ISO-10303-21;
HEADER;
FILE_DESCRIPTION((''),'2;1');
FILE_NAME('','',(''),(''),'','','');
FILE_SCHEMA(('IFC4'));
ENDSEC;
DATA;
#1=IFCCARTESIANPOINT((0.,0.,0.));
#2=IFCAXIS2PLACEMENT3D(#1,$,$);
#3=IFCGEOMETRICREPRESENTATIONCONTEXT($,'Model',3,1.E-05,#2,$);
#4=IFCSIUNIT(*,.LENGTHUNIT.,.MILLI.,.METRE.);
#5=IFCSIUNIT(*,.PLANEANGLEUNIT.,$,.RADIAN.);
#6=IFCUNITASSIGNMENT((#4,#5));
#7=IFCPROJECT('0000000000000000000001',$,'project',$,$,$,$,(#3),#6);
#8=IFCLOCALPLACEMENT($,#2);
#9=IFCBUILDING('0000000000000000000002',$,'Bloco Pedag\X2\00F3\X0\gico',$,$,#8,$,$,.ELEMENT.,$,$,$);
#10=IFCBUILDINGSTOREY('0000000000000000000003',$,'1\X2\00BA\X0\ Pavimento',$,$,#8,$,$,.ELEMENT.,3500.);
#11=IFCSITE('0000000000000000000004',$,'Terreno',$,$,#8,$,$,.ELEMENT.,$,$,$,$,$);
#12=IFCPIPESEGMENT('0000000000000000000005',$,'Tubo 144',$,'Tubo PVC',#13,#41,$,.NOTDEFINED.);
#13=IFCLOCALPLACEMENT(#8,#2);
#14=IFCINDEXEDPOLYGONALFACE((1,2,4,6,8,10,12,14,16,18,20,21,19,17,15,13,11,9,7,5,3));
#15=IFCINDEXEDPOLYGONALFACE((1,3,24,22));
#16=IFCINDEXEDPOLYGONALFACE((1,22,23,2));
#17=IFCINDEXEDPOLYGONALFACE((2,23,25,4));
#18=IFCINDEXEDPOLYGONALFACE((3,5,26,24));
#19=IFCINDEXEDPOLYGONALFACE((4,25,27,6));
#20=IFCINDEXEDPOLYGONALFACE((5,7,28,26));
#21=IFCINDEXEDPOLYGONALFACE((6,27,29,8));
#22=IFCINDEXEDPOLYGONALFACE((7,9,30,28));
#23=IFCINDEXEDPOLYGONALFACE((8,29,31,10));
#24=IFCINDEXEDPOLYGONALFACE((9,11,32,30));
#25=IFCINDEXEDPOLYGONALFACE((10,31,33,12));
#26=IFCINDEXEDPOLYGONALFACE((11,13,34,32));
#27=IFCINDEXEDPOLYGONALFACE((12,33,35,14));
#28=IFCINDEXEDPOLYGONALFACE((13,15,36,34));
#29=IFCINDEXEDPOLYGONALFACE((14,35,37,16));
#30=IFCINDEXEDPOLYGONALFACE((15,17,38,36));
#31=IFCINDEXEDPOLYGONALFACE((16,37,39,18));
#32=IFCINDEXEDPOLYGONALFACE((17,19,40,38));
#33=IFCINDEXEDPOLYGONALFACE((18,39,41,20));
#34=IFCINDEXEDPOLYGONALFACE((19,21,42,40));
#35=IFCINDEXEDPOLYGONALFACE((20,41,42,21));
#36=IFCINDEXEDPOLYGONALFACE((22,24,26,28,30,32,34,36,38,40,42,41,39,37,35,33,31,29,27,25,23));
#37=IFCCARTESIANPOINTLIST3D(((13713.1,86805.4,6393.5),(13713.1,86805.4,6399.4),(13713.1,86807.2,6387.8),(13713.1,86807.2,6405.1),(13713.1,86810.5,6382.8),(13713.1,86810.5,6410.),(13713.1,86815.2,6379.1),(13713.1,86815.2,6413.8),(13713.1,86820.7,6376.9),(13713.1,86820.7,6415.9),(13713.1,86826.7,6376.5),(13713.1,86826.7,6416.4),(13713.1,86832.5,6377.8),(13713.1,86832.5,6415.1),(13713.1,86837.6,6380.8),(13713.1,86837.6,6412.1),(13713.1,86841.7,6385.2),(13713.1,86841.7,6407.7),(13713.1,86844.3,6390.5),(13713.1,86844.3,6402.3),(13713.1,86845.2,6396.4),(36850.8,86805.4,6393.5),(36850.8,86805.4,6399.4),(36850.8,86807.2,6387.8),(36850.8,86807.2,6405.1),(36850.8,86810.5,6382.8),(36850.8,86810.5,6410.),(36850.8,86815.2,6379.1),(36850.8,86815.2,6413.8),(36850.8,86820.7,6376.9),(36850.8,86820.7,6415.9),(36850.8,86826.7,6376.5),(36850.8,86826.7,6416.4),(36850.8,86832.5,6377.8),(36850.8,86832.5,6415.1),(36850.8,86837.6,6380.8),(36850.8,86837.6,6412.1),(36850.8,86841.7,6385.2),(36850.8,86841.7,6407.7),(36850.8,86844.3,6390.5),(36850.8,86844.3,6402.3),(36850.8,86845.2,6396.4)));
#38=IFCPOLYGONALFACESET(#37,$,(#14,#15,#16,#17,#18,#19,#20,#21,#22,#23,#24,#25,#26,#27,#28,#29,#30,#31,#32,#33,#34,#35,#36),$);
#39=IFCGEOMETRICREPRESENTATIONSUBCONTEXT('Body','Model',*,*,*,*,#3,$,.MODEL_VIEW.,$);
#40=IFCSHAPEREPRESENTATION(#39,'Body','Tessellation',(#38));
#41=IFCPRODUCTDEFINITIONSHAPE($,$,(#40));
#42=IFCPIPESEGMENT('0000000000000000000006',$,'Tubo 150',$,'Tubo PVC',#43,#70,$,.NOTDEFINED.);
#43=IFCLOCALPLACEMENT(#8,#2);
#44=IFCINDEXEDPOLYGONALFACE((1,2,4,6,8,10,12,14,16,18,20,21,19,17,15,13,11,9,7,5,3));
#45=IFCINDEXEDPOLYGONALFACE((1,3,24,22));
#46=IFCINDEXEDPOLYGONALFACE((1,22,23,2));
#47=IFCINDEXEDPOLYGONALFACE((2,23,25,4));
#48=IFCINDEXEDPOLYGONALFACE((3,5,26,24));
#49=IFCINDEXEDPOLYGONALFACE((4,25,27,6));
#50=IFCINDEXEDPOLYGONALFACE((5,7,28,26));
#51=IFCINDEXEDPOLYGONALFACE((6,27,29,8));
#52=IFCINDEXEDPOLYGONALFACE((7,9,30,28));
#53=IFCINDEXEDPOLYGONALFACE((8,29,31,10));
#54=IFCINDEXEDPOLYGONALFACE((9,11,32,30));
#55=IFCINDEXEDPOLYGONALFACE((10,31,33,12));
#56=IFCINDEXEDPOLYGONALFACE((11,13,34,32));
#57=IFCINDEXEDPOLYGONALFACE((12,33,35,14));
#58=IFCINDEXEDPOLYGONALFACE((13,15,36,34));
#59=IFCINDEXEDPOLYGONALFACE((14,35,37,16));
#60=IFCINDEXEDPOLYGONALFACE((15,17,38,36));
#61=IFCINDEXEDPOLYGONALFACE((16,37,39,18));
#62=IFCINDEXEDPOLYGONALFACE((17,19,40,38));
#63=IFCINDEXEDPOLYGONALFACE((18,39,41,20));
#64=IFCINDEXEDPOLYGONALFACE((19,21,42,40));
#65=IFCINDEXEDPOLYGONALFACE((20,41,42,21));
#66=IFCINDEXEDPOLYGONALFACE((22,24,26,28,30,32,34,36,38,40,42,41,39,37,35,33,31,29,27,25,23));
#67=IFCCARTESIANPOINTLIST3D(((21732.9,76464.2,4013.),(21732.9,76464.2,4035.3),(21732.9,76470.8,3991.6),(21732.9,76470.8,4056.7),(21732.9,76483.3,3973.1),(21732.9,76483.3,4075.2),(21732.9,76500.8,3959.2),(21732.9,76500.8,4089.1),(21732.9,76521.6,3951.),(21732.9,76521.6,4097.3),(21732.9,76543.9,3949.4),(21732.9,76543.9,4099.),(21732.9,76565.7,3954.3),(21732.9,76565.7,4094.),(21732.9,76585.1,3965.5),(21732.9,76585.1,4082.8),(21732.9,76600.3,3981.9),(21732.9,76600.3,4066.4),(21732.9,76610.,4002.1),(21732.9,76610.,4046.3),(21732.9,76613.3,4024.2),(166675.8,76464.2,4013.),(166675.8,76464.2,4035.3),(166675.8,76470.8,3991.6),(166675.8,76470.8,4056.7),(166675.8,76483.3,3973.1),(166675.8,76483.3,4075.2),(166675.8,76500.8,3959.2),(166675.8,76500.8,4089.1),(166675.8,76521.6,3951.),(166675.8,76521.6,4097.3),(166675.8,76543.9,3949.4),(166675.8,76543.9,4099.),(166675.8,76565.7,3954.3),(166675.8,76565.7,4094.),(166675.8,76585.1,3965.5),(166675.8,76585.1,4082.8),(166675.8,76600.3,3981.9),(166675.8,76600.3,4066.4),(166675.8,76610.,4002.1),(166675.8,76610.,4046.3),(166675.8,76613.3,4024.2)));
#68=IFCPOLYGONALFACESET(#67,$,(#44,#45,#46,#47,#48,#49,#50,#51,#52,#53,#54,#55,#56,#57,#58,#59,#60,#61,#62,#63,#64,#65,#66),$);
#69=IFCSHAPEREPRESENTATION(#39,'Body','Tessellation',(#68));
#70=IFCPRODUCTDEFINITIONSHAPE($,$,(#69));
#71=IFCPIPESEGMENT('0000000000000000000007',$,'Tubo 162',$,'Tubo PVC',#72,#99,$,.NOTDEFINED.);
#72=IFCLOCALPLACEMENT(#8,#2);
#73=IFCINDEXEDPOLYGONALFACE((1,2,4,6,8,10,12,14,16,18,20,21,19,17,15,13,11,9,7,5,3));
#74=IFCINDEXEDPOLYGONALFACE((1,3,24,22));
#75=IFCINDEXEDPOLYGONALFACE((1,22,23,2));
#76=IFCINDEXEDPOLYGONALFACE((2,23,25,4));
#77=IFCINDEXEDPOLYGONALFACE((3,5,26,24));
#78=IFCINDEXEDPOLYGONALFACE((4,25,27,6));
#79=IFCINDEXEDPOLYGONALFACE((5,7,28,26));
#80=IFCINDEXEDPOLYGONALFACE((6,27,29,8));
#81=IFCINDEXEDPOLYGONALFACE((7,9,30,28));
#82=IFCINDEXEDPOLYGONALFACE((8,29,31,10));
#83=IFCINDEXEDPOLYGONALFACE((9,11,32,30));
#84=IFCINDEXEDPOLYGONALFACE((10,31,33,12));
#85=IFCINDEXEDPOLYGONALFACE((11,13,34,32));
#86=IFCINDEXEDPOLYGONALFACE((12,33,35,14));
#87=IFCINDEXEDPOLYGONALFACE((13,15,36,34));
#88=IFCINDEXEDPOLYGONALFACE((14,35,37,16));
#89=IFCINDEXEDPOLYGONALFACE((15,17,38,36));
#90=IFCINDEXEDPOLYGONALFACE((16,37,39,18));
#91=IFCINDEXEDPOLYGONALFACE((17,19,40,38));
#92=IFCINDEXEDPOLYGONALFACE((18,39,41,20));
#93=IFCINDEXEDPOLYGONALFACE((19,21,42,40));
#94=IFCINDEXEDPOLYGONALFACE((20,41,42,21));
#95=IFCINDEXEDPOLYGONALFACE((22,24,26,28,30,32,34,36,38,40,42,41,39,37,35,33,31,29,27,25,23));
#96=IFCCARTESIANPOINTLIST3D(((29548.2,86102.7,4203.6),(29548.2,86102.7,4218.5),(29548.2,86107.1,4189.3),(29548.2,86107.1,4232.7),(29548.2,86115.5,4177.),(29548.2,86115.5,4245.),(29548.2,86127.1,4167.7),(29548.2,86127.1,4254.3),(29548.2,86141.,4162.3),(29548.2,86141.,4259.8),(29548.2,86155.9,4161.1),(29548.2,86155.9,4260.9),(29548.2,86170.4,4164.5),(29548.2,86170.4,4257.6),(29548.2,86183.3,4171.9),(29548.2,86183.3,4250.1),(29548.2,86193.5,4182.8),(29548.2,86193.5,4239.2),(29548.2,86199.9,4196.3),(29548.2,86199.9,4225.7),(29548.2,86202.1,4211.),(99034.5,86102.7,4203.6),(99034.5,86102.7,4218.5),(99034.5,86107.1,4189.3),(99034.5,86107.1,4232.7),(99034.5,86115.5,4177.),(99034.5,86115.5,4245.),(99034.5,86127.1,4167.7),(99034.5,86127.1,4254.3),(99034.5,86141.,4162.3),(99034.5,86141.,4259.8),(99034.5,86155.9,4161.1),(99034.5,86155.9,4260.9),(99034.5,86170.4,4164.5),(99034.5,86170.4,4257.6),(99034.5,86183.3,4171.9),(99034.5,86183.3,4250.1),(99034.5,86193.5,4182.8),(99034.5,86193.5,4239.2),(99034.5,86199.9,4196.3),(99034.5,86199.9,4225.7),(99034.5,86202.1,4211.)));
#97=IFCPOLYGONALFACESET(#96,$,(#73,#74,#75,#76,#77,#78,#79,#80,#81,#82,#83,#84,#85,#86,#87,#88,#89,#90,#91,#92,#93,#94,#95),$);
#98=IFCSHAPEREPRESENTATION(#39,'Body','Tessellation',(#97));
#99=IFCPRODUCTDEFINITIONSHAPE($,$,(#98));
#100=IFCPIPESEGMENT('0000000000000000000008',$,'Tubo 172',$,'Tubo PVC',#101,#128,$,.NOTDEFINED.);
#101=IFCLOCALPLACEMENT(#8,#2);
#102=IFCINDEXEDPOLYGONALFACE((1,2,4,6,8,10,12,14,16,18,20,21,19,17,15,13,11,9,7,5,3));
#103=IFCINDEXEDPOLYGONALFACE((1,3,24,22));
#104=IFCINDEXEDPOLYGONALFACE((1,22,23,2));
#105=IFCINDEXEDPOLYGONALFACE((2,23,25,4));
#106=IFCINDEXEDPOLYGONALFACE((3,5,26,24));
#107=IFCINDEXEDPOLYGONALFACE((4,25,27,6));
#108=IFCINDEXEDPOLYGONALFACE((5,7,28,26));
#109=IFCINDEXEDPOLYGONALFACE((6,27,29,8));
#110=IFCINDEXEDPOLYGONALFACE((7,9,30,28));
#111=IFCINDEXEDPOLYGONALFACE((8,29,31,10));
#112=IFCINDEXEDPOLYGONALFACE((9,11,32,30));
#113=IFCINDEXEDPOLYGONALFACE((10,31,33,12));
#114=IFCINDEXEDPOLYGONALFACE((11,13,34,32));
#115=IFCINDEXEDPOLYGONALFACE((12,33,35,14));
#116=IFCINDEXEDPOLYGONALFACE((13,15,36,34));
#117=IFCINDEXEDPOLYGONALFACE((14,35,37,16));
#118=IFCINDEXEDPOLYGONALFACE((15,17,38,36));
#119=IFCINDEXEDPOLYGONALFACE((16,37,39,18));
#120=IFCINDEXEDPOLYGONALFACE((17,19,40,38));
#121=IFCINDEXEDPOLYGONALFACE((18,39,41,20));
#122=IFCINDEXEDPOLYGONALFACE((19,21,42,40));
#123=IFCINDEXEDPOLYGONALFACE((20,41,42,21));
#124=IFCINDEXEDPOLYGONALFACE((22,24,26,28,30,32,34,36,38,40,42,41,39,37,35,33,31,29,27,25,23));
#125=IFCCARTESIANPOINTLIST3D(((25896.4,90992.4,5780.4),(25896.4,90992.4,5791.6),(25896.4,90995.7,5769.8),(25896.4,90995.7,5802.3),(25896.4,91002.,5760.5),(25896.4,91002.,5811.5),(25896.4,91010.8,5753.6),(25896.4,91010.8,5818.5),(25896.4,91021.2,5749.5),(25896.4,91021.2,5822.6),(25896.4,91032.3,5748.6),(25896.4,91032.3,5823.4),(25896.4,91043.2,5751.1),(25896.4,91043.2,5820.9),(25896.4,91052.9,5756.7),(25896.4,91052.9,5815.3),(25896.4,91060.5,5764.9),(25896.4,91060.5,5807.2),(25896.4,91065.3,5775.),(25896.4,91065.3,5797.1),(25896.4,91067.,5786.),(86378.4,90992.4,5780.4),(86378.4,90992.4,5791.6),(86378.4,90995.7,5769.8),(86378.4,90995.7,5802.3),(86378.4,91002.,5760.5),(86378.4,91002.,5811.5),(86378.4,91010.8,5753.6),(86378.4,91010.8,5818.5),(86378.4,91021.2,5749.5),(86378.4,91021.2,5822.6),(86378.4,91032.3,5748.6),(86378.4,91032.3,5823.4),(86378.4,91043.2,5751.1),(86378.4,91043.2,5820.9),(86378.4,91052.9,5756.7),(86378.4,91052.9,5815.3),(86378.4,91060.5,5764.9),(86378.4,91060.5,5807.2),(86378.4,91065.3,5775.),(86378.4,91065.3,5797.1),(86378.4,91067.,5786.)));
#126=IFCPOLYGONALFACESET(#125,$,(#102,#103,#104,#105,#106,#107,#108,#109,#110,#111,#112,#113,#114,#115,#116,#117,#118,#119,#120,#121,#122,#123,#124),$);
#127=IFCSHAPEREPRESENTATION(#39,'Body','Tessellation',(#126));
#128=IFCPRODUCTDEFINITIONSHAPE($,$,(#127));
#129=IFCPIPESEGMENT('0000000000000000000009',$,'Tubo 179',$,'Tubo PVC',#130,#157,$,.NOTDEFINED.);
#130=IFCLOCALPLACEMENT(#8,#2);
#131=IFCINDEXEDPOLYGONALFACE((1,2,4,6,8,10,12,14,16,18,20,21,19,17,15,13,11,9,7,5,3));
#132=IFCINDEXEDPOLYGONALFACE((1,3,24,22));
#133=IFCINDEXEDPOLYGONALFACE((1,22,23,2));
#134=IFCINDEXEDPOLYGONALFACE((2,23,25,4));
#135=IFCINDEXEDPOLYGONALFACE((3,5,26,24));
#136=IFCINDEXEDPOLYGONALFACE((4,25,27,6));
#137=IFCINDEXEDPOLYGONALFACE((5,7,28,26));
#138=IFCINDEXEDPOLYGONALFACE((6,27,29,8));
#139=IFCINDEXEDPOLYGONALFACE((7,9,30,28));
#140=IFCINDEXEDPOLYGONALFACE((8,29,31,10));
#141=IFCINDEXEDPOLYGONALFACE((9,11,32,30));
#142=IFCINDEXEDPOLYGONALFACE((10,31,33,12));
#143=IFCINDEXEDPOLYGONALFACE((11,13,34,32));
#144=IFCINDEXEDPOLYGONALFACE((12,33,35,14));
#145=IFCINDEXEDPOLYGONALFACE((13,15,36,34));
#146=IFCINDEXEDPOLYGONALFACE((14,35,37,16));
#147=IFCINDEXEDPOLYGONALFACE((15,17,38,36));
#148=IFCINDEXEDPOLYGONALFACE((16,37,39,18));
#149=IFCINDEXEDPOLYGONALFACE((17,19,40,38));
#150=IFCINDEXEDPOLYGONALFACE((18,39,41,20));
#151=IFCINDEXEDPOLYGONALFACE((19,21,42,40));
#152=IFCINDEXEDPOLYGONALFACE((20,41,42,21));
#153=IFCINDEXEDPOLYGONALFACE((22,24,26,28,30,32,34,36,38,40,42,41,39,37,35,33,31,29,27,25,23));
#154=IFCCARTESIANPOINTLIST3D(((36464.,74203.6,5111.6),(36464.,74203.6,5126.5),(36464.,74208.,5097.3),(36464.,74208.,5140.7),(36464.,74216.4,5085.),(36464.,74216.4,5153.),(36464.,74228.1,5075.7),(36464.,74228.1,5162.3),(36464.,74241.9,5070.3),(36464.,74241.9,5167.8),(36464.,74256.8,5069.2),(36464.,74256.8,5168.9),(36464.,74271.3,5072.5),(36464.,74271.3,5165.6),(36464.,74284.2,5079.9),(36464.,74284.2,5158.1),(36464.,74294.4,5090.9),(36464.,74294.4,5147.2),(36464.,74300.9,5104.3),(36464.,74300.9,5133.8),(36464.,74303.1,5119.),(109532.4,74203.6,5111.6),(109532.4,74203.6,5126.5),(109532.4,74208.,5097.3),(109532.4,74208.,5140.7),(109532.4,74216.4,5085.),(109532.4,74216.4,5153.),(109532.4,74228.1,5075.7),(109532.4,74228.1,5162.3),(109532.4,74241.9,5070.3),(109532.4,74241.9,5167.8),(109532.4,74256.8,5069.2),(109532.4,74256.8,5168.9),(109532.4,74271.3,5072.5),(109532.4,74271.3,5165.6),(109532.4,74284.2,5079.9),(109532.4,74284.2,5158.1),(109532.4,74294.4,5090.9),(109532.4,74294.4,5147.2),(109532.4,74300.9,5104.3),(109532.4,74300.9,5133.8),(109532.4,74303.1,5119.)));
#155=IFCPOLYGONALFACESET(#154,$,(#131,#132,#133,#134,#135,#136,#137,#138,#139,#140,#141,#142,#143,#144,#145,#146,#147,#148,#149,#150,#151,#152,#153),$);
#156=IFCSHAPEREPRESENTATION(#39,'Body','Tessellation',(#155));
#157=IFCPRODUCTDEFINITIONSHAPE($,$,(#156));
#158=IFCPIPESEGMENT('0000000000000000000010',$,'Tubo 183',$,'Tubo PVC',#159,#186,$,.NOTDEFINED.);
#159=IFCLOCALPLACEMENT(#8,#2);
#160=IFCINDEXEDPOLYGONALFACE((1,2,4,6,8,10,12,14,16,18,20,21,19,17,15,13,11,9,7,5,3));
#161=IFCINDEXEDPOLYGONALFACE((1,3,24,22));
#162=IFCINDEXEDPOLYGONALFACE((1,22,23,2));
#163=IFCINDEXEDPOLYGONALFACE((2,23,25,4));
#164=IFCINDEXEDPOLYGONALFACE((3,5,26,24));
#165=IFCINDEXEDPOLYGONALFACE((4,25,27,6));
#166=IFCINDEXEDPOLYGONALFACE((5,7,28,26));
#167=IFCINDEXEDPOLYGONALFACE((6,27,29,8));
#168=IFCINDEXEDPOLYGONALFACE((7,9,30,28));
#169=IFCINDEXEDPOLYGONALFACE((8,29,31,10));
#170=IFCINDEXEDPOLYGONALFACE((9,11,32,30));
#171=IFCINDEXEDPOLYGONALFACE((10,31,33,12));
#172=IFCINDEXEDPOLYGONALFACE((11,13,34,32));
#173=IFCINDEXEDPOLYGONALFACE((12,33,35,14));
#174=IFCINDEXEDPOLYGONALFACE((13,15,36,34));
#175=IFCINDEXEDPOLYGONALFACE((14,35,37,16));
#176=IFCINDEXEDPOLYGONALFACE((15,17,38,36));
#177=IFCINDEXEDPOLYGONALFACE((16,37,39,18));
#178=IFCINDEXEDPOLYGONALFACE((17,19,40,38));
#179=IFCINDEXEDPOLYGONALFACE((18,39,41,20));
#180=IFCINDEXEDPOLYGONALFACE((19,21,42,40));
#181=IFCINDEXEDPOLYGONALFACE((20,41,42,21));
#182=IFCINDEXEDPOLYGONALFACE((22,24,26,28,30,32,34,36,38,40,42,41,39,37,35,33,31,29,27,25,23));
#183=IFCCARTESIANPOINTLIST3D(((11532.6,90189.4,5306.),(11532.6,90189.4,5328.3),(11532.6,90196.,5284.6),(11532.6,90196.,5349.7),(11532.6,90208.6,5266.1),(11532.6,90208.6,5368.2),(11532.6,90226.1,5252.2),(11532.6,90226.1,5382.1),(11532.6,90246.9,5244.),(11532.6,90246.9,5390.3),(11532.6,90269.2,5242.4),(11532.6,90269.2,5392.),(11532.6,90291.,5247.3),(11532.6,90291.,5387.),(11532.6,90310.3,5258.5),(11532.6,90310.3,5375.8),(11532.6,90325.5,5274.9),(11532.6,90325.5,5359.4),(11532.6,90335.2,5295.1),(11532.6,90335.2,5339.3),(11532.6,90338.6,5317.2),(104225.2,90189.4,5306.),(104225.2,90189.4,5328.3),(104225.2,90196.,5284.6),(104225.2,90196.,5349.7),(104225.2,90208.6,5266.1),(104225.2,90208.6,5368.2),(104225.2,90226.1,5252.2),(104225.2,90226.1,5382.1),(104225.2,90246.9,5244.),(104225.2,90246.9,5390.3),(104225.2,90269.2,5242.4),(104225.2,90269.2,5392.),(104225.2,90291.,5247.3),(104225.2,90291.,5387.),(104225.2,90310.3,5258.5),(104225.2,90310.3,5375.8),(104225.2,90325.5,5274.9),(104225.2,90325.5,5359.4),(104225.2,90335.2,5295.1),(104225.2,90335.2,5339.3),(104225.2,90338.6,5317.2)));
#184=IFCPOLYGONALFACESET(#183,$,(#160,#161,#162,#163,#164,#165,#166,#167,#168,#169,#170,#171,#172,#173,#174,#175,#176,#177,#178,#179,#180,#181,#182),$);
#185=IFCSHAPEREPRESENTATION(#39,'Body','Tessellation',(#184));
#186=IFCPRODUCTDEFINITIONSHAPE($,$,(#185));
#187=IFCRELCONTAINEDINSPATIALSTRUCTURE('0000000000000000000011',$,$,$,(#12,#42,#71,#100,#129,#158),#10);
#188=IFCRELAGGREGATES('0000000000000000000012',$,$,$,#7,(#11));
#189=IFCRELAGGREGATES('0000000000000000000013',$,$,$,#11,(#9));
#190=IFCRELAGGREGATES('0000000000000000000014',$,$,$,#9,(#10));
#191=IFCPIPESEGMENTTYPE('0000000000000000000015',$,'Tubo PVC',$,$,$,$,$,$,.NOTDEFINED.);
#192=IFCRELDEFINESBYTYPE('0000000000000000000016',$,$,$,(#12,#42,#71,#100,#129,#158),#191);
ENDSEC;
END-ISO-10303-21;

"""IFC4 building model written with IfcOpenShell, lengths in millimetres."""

from ifc_helpers import new_model, si_unit, frame, origin, origin_2d, place, context, subcontext, project, spatial, circle, extrude, type_object, element, save


model = new_model("IFC4")

# Units and contexts
model_context = context("Model", 3, precision=1e-05, world=origin())
body_context = subcontext(model_context, "Body", "Model", "MODEL_VIEW")
ifc_project = project(units=[si_unit("LENGTHUNIT", "METRE", prefix="MILLI"), si_unit("PLANEANGLEUNIT", "RADIAN")], contexts=[model_context])

# Site, building, storey
placement = place(None, origin())
site = spatial("IfcSite", under=ifc_project, at=placement, Name="Terreno", CompositionType="ELEMENT")
building = spatial("IfcBuilding", under=site, at=placement, Name="Bloco Pedagógico", CompositionType="ELEMENT")
storey = spatial("IfcBuildingStorey", under=building, at=placement, Name="1º Pavimento", CompositionType="ELEMENT", Elevation=3500.0)

# Pipe segments
pipe_segment_type = type_object("IfcPipeSegmentType", Name="Tubo PVC", PredefinedType="NOTDEFINED")
pipe_segment_1_placement = place(None, frame((13713.1, 86825.2, 6396.4), z_axis=(1.0, 0.0, 0.0), x_axis=(0.0, 1.0, 0.0)))
element("IfcPipeSegment", 1, at=pipe_segment_1_placement, inside=storey, type_object=pipe_segment_type, Name="Tubo 144", ObjectType="Tubo PVC", PredefinedType="NOTDEFINED", context=body_context, shape_type="SweptSolid", body=[
    extrude(circle(Radius=20.0, at=origin_2d()), None, (0.0, 0.0, 1.0), 23137.7),
])
pipe_segment_2_placement = place(None, frame((21732.9, 76538.3, 4024.2), z_axis=(1.0, 0.0, 0.0), x_axis=(0.0, 1.0, 0.0)))
element("IfcPipeSegment", 2, at=pipe_segment_2_placement, inside=storey, type_object=pipe_segment_type, Name="Tubo 150", ObjectType="Tubo PVC", PredefinedType="NOTDEFINED", context=body_context, shape_type="SweptSolid", body=[
    extrude(circle(Radius=75.0, at=origin_2d()), None, (0.0, 0.0, 1.0), 144942.9),
])
pipe_segment_3_placement = place(None, frame((29548.2, 86152.1, 4211.0), z_axis=(1.0, 0.0, 0.0), x_axis=(0.0, 1.0, 0.0)))
element("IfcPipeSegment", 3, at=pipe_segment_3_placement, inside=storey, type_object=pipe_segment_type, Name="Tubo 162", ObjectType="Tubo PVC", PredefinedType="NOTDEFINED", context=body_context, shape_type="SweptSolid", body=[
    extrude(circle(Radius=50.0, at=origin_2d()), None, (0.0, 0.0, 1.0), 69486.3),
])
pipe_segment_4_placement = place(None, frame((25896.4, 91029.5, 5786.0), z_axis=(1.0, 0.0, 0.0), x_axis=(0.0, 1.0, 0.0)))
element("IfcPipeSegment", 4, at=pipe_segment_4_placement, inside=storey, type_object=pipe_segment_type, Name="Tubo 172", ObjectType="Tubo PVC", PredefinedType="NOTDEFINED", context=body_context, shape_type="SweptSolid", body=[
    extrude(circle(Radius=37.5, at=origin_2d()), None, (0.0, 0.0, 1.0), 60482.0),
])
pipe_segment_5_placement = place(None, frame((36464.0, 74253.1, 5119.0), z_axis=(1.0, 0.0, 0.0), x_axis=(0.0, 1.0, 0.0)))
element("IfcPipeSegment", 5, at=pipe_segment_5_placement, inside=storey, type_object=pipe_segment_type, Name="Tubo 179", ObjectType="Tubo PVC", PredefinedType="NOTDEFINED", context=body_context, shape_type="SweptSolid", body=[
    extrude(circle(Radius=50.0, at=origin_2d()), None, (0.0, 0.0, 1.0), 73068.4),
])
pipe_segment_6_placement = place(None, frame((11532.6, 90263.6, 5317.2), z_axis=(1.0, 0.0, 0.0), x_axis=(0.0, 1.0, 0.0)))
element("IfcPipeSegment", 6, at=pipe_segment_6_placement, inside=storey, type_object=pipe_segment_type, Name="Tubo 183", ObjectType="Tubo PVC", PredefinedType="NOTDEFINED", context=body_context, shape_type="SweptSolid", body=[
    extrude(circle(Radius=75.0, at=origin_2d()), None, (0.0, 0.0, 1.0), 92692.6),
])

save(model, "model.ifc")
